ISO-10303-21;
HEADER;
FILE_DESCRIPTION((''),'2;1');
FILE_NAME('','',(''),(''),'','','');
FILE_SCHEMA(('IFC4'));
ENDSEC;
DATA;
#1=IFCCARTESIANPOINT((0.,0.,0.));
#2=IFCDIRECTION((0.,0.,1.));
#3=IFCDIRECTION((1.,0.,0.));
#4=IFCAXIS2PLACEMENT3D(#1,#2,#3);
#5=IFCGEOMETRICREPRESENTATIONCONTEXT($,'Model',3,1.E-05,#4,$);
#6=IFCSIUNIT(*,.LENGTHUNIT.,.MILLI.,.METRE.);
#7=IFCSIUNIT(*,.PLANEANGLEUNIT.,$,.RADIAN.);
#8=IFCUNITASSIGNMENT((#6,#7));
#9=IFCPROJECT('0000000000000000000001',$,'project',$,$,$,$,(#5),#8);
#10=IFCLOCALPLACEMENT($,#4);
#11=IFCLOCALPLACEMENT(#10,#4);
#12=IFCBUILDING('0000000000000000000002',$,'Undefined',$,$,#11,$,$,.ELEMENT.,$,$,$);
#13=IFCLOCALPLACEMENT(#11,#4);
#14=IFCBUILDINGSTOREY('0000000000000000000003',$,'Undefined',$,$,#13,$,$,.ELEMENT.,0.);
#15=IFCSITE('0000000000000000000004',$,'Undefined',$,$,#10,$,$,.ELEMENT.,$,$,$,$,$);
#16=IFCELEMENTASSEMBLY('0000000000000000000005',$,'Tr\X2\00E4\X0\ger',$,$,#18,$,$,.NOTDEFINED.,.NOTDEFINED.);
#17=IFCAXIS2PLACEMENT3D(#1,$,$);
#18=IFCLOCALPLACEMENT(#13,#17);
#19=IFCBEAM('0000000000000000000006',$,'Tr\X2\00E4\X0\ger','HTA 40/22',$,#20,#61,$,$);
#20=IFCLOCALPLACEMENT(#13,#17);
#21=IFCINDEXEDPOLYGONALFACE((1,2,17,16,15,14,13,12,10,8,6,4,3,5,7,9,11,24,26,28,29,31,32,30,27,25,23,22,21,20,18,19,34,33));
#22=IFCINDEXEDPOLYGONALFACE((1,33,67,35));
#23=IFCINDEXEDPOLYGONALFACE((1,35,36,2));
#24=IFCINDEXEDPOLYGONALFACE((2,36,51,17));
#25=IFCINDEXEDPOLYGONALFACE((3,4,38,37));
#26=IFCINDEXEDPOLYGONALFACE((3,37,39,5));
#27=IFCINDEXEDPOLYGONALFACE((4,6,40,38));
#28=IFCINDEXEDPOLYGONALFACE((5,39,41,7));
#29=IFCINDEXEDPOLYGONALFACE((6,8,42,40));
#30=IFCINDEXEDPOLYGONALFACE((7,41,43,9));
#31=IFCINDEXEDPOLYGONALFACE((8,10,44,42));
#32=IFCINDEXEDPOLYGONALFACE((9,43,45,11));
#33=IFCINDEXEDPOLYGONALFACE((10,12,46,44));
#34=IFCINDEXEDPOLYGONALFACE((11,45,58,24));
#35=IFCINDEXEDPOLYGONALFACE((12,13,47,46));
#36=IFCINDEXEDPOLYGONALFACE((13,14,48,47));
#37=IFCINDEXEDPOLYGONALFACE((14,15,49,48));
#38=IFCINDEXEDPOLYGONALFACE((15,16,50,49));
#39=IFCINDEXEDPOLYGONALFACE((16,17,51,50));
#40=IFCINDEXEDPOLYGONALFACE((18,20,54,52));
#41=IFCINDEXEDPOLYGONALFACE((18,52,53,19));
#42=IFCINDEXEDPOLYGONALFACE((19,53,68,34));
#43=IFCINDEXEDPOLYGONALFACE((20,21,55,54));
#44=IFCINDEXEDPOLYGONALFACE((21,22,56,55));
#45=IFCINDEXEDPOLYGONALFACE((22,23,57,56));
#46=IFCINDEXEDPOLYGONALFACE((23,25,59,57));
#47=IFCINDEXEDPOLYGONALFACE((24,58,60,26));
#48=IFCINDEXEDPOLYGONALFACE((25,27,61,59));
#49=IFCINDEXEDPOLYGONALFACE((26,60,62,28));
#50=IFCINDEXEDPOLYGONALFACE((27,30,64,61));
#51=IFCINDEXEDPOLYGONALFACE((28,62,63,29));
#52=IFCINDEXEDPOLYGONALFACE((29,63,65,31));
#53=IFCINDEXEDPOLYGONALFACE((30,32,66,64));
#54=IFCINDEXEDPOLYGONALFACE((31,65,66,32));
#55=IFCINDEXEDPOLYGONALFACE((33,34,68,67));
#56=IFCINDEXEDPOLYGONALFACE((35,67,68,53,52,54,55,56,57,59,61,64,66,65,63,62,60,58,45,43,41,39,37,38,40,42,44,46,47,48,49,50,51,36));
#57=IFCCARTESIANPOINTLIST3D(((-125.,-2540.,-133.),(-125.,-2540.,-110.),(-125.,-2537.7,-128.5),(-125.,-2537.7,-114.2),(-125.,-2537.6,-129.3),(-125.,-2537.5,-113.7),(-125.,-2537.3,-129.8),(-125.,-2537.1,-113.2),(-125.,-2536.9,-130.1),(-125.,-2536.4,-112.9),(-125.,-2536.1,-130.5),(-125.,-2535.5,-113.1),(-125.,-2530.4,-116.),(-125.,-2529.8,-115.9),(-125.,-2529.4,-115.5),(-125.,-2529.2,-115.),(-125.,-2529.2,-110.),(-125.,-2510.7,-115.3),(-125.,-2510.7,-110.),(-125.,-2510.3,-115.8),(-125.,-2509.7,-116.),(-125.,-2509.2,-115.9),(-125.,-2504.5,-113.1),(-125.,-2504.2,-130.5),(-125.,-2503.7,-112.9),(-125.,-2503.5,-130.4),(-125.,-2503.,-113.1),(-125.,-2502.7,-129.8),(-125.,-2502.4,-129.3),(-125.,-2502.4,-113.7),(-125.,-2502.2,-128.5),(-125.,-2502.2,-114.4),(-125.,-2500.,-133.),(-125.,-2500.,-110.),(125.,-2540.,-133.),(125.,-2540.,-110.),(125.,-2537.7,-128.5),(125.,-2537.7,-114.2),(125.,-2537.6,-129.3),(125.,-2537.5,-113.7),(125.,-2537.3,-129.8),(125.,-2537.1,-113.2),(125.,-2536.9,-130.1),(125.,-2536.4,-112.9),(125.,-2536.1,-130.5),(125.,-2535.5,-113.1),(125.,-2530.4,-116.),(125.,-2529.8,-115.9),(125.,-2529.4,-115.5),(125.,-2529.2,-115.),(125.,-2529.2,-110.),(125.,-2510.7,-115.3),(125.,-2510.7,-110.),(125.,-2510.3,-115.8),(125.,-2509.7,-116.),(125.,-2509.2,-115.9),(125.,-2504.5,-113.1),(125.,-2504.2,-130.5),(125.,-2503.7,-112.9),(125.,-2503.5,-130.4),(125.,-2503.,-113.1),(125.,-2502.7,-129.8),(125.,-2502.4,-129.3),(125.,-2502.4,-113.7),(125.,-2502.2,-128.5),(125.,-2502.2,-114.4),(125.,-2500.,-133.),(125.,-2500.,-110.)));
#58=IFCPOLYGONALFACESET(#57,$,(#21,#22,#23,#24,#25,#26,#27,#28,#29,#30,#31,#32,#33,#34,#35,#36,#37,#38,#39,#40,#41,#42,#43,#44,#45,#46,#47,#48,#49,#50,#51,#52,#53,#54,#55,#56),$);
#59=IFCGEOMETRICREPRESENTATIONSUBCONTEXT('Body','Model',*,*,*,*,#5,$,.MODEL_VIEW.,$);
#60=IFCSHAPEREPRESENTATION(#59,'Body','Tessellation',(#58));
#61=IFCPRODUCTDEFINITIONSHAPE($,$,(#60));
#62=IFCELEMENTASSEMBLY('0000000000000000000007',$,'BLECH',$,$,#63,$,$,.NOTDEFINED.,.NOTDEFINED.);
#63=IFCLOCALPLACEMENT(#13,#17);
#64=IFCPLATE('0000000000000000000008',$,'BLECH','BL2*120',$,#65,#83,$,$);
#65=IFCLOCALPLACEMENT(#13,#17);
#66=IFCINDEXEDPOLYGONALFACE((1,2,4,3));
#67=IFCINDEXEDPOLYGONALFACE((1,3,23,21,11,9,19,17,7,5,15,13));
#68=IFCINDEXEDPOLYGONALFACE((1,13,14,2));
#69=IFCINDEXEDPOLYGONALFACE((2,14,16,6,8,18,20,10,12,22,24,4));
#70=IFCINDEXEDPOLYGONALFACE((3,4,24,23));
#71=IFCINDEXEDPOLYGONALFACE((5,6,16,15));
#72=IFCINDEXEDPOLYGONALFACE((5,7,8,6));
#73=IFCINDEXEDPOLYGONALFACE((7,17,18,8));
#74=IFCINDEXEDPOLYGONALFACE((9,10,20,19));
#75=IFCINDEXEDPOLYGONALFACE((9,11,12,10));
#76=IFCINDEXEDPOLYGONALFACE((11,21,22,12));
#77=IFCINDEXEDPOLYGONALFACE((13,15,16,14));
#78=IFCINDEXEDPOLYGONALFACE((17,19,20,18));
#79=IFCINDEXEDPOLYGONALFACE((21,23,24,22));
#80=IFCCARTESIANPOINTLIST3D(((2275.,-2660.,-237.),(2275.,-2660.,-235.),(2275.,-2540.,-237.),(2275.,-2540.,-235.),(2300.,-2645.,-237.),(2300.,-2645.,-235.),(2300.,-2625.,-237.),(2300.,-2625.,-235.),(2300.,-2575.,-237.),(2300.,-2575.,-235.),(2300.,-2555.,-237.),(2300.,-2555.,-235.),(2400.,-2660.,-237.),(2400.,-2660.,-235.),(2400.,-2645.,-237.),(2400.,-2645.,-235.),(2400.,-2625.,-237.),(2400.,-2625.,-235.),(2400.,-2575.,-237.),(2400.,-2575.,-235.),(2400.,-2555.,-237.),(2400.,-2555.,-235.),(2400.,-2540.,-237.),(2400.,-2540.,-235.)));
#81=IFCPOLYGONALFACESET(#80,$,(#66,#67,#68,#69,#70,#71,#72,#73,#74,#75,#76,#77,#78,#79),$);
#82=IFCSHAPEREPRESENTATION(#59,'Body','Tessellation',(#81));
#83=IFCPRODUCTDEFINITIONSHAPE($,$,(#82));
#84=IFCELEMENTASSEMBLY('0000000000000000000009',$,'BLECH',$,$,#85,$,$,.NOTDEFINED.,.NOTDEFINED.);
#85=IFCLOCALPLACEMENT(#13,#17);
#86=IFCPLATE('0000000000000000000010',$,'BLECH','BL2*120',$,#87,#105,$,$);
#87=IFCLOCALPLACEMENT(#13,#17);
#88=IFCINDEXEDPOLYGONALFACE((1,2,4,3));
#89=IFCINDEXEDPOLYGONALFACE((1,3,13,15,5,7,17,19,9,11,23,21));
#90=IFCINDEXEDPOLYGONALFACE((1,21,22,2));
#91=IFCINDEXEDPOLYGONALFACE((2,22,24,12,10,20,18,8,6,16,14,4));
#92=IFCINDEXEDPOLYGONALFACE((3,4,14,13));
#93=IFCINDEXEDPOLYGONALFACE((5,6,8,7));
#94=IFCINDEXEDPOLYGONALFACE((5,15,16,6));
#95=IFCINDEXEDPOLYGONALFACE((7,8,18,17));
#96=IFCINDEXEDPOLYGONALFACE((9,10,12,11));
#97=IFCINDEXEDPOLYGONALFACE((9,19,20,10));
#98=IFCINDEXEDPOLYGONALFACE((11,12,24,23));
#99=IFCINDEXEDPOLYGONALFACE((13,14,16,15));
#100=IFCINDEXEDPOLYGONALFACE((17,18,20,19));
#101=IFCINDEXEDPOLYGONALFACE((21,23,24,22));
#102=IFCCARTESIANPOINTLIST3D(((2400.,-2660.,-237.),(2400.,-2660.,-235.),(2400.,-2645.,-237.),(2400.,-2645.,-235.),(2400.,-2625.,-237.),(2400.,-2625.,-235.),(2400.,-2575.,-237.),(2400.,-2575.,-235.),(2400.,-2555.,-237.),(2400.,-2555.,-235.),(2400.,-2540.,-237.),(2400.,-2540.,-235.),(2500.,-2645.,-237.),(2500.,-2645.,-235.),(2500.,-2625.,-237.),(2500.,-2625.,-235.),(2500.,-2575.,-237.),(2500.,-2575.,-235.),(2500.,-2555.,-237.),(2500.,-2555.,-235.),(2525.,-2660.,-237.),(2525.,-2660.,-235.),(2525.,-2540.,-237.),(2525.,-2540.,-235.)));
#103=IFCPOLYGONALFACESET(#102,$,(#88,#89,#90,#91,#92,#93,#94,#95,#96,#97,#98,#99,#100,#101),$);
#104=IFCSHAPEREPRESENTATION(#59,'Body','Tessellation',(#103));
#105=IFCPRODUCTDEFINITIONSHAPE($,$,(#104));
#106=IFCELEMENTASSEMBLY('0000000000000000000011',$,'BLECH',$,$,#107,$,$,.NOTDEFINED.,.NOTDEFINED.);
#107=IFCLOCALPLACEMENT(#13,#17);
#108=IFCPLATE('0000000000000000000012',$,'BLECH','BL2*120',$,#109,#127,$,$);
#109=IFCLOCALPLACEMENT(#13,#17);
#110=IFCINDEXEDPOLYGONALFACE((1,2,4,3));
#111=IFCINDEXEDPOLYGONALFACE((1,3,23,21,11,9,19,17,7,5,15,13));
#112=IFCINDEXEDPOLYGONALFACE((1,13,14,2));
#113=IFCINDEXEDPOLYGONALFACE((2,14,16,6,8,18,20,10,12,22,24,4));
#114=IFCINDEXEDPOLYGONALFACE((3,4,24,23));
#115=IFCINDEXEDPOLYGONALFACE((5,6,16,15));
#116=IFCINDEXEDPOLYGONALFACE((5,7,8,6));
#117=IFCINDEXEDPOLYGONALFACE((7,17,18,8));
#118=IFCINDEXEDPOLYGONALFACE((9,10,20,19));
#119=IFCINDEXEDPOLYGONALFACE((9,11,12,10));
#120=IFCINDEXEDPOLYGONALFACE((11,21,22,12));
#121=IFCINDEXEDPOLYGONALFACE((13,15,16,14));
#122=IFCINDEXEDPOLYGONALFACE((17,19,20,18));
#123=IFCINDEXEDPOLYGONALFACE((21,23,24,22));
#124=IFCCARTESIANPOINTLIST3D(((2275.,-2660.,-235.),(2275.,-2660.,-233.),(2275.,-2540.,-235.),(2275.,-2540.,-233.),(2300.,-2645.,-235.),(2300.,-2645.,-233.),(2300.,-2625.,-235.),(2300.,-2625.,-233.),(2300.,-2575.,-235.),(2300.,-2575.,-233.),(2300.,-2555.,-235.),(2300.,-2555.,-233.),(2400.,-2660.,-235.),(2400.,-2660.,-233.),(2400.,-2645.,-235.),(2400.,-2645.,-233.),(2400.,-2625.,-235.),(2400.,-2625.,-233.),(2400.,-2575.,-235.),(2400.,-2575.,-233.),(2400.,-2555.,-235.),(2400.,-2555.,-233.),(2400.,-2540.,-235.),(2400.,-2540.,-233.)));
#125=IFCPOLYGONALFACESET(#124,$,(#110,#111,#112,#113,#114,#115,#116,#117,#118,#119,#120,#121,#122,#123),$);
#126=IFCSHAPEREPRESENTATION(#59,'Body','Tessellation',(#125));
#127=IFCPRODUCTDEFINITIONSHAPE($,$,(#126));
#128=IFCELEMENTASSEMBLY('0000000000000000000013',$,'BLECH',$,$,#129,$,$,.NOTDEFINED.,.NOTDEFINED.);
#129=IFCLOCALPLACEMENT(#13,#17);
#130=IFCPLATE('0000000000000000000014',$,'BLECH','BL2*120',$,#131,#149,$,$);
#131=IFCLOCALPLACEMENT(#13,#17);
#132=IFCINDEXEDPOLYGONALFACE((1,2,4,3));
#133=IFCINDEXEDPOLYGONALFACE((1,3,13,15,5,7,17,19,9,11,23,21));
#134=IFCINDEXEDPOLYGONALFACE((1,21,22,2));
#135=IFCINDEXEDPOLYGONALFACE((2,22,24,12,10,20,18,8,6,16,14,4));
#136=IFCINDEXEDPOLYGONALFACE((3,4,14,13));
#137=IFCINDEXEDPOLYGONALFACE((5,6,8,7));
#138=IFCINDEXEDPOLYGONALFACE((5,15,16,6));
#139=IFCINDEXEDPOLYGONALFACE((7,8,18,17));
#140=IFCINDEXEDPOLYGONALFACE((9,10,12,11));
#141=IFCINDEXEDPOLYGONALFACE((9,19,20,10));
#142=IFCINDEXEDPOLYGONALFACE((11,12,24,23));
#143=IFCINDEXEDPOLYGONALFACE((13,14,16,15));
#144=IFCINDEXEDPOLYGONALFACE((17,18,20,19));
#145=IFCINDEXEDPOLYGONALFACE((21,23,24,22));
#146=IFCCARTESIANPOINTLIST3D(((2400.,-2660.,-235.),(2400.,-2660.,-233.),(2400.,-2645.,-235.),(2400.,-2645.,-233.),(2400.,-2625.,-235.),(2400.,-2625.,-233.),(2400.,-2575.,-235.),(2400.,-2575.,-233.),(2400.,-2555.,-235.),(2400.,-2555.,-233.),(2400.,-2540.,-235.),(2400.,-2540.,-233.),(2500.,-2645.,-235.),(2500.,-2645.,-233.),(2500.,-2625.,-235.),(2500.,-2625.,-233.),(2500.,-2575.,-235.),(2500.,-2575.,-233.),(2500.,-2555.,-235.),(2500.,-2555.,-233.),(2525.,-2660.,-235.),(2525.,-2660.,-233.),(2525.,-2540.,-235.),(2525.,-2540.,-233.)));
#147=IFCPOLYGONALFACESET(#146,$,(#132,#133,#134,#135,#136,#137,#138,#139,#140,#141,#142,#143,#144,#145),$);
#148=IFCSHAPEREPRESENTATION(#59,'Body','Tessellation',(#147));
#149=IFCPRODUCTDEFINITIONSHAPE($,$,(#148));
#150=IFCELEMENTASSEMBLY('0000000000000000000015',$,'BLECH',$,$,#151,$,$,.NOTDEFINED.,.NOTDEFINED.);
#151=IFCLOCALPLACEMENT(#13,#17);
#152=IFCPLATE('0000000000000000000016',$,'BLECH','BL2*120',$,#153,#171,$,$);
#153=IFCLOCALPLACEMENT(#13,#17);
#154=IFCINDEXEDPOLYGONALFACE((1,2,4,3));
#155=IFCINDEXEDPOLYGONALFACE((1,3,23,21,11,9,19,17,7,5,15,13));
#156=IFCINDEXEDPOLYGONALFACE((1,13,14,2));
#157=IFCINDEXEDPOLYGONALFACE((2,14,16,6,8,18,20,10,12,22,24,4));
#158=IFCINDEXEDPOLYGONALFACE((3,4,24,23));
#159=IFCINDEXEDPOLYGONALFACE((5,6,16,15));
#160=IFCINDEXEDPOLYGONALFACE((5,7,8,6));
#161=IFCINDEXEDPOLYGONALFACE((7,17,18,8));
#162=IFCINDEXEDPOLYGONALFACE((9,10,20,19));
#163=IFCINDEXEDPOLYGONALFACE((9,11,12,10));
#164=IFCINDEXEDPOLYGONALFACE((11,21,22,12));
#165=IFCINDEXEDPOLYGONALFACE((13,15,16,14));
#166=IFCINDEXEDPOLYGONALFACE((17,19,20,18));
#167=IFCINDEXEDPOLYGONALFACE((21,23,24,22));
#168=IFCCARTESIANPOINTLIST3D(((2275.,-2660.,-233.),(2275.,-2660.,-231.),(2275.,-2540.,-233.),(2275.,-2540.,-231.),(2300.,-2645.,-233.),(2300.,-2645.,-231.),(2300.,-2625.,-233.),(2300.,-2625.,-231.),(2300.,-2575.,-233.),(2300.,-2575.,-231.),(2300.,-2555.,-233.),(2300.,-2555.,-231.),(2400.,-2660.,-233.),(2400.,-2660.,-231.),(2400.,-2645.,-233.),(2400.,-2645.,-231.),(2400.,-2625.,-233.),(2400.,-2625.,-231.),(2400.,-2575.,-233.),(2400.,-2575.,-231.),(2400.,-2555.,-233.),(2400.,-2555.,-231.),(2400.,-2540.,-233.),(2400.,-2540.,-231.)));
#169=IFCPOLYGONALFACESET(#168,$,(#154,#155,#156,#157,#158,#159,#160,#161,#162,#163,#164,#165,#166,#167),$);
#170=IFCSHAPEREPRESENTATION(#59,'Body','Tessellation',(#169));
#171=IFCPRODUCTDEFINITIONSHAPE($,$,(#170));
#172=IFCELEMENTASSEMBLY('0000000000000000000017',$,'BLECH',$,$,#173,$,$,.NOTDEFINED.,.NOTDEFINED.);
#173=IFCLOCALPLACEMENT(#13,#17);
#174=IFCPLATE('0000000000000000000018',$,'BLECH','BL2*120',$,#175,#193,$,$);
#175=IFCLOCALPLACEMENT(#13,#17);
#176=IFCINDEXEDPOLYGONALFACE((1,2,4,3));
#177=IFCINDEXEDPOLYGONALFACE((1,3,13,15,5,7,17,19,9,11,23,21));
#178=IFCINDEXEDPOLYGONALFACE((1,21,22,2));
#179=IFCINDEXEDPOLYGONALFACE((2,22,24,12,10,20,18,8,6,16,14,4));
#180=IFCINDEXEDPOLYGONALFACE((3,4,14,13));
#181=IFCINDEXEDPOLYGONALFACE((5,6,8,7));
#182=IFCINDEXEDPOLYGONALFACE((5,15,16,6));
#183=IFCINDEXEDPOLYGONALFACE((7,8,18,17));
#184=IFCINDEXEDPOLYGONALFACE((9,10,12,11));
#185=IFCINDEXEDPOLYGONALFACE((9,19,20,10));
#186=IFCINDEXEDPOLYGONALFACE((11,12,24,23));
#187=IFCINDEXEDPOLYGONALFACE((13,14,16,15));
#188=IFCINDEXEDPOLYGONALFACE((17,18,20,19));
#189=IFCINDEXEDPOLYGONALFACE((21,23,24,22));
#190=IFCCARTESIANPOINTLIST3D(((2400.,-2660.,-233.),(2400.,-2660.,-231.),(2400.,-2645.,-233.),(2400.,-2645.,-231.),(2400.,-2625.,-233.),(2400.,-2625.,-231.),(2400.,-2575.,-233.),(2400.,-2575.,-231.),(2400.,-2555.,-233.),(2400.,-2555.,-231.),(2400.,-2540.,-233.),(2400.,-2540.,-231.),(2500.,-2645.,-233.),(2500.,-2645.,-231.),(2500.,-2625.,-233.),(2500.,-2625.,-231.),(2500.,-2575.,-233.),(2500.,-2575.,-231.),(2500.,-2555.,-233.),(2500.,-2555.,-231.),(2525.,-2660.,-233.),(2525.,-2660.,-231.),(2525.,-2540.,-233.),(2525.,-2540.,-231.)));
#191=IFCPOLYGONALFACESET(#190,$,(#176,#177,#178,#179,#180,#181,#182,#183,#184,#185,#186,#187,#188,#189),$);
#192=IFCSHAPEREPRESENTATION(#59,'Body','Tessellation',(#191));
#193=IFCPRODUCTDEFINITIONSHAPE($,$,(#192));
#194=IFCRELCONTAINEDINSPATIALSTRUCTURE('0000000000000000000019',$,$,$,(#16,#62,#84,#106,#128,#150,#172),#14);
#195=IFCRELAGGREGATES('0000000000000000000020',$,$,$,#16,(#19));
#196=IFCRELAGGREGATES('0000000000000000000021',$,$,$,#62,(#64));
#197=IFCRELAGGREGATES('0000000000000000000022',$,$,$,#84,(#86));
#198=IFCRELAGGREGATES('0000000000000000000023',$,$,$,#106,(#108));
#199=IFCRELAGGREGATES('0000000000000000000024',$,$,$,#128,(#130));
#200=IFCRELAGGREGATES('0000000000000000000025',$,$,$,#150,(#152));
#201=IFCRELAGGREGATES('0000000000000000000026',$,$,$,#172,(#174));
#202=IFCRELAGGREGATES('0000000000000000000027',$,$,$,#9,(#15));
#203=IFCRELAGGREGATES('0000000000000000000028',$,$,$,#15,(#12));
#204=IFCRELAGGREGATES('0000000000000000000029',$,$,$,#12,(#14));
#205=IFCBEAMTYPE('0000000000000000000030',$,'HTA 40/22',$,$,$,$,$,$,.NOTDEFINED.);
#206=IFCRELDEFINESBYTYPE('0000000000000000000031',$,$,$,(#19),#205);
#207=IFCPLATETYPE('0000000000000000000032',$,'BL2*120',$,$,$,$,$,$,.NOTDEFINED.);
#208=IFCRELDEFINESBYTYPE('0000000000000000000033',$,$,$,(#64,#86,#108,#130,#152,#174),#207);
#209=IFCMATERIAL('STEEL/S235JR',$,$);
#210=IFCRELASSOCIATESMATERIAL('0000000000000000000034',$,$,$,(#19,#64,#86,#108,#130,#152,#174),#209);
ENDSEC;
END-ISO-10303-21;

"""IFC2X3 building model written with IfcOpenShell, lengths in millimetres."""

from ifc_helpers import new_model, si_unit, frame, origin_with_axes, place, context, subcontext, project, spatial, polyline, outline, extrude, material, type_object, element, aggregate, save


model = new_model("IFC2X3")

# Units and contexts
model_context = context("Model", 3, precision=1e-05, world=origin_with_axes())
body_context = subcontext(model_context, "Body", "Model", "MODEL_VIEW")
ifc_project = project(units=[si_unit("LENGTHUNIT", "METRE", prefix="MILLI"), si_unit("PLANEANGLEUNIT", "RADIAN")], contexts=[model_context])

# Site, building, storey
site_placement = place(None, origin_with_axes())
site = spatial("IfcSite", under=ifc_project, at=site_placement, Name="Undefined", CompositionType="ELEMENT")
building_placement = place(site_placement, origin_with_axes())
building = spatial("IfcBuilding", under=site, at=building_placement, Name="Undefined", CompositionType="ELEMENT")
storey_placement = place(building_placement, origin_with_axes())
storey = spatial("IfcBuildingStorey", under=building, at=storey_placement, Name="Undefined", CompositionType="ELEMENT", Elevation=0.0)

# Element assembly, beam
assembly_1_placement = place(storey_placement, origin_with_axes())
assembly_1 = element("IfcElementAssembly", 1, at=assembly_1_placement, inside=storey, Name="Träger", AssemblyPlace="NOTDEFINED", PredefinedType="NOTDEFINED")
ifc_material = material(Name="STEEL/S235JR")
beam_type = type_object("IfcBeamType", Name="HTA 40/22", PredefinedType="NOTDEFINED")
beam_placement = place(assembly_1_placement, frame((125.0, -2520.0, -121.5), z_axis=(0.0, 0.0, -1.0), x_axis=(-1.0, 0.0, 0.0)))
beam = element("IfcBeam", 2, at=beam_placement, type_object=beam_type, material=ifc_material, Name="Träger", Description="HTA 40/22", context=body_context, shape_type="SweptSolid", body=[
    extrude(outline(polyline([(-9.3, -6.2), (-9.2, -11.5), (-20.0, -11.5), (-20.0, 11.5), (20.0, 11.5), (20.0, -11.5), (9.2, -11.5), (9.2, -6.5), (9.4, -6.0), (9.8, -5.6), (10.4, -5.5), (15.5, -8.4), (16.4, -8.6), (17.1, -8.3), (17.5, -7.8), (17.7, -7.3), (17.8, 7.0), (17.6, 7.8), (17.3, 8.3), (16.9, 8.6), (16.1, 9.0), (-15.8, 9.0), (-16.5, 8.9), (-17.3, 8.3), (-17.6, 7.8), (-17.8, 7.0), (-17.8, -7.1), (-17.5, -7.8), (-17.0, -8.4), (-16.2, -8.6), (-15.5, -8.4), (-10.8, -5.6), (-10.2, -5.5), (-9.7, -5.7), (-9.3, -6.2)])), frame((250.0, 0.0, 0.0), z_axis=(-1.0, 0.0, 0.0), x_axis=(0.0, -1.0, 0.0)), (0.0, 0.0, 1.0), 250.0),
])
aggregate(assembly_1, [beam])

# Element assemblies, plates
assembly_2_placement = place(storey_placement, origin_with_axes())
assembly_2 = element("IfcElementAssembly", 3, at=assembly_2_placement, inside=storey, Name="BLECH", AssemblyPlace="NOTDEFINED", PredefinedType="NOTDEFINED")
plate_type_1 = type_object("IfcPlateType", Name="BL2*120", PredefinedType="NOTDEFINED")
plate_1_placement = place(assembly_2_placement, frame((2275.0, -2540.0, -236.0), z_axis=(0.0, 0.0, -1.0), x_axis=(1.0, 0.0, 0.0)))
plate_1 = element("IfcPlate", 4, at=plate_1_placement, type_object=plate_type_1, material=ifc_material, Name="BLECH", Description="BL2*120", context=body_context, shape_type="SweptSolid", body=[
    extrude(outline(polyline([(0.0, 0.0), (125.0, 0.0), (125.0, 15.0), (25.0, 15.0), (25.0, 35.0), (125.0, 35.0), (125.0, 85.0), (25.0, 85.0), (25.0, 105.0), (125.0, 105.0), (125.0, 120.0), (0.0, 120.0), (0.0, 0.0)])), frame((0.0, 0.0, -1.0), z_axis=(0.0, 0.0, 1.0), x_axis=(1.0, 0.0, 0.0)), (0.0, 0.0, 1.0), 2.0),
])
aggregate(assembly_2, [plate_1])
assembly_3_placement = place(storey_placement, origin_with_axes())
assembly_3 = element("IfcElementAssembly", 5, at=assembly_3_placement, inside=storey, Name="BLECH", AssemblyPlace="NOTDEFINED", PredefinedType="NOTDEFINED")
plate_2_placement = place(assembly_3_placement, frame((2525.0, -2540.0, -236.0), z_axis=(0.0, 0.0, 1.0), x_axis=(-1.0, 0.0, 0.0)))
plate_2 = element("IfcPlate", 6, at=plate_2_placement, type_object=plate_type_1, material=ifc_material, Name="BLECH", Description="BL2*120", context=body_context, shape_type="SweptSolid", body=[
    extrude(outline(polyline([(0.0, 0.0), (125.0, 0.0), (125.0, 15.0), (25.0, 15.0), (25.0, 35.0), (125.0, 35.0), (125.0, 85.0), (25.0, 85.0), (25.0, 105.0), (125.0, 105.0), (125.0, 120.0), (0.0, 120.0), (0.0, 0.0)])), frame((0.0, 0.0, -1.0), z_axis=(0.0, 0.0, 1.0), x_axis=(1.0, 0.0, 0.0)), (0.0, 0.0, 1.0), 2.0),
])
aggregate(assembly_3, [plate_2])
assembly_4_placement = place(storey_placement, origin_with_axes())
assembly_4 = element("IfcElementAssembly", 7, at=assembly_4_placement, inside=storey, Name="BLECH", AssemblyPlace="NOTDEFINED", PredefinedType="NOTDEFINED")
plate_3_placement = place(assembly_4_placement, frame((2275.0, -2540.0, -234.0), z_axis=(0.0, 0.0, -1.0), x_axis=(1.0, 0.0, 0.0)))
plate_3 = element("IfcPlate", 8, at=plate_3_placement, type_object=plate_type_1, material=ifc_material, Name="BLECH", Description="BL2*120", context=body_context, shape_type="SweptSolid", body=[
    extrude(outline(polyline([(0.0, 0.0), (125.0, 0.0), (125.0, 15.0), (25.0, 15.0), (25.0, 35.0), (125.0, 35.0), (125.0, 85.0), (25.0, 85.0), (25.0, 105.0), (125.0, 105.0), (125.0, 120.0), (0.0, 120.0), (0.0, 0.0)])), frame((0.0, 0.0, -1.0), z_axis=(0.0, 0.0, 1.0), x_axis=(1.0, 0.0, 0.0)), (0.0, 0.0, 1.0), 2.0),
])
aggregate(assembly_4, [plate_3])
assembly_5_placement = place(storey_placement, origin_with_axes())
assembly_5 = element("IfcElementAssembly", 9, at=assembly_5_placement, inside=storey, Name="BLECH", AssemblyPlace="NOTDEFINED", PredefinedType="NOTDEFINED")
plate_4_placement = place(assembly_5_placement, frame((2525.0, -2540.0, -234.0), z_axis=(0.0, 0.0, 1.0), x_axis=(-1.0, 0.0, 0.0)))
plate_4 = element("IfcPlate", 10, at=plate_4_placement, type_object=plate_type_1, material=ifc_material, Name="BLECH", Description="BL2*120", context=body_context, shape_type="SweptSolid", body=[
    extrude(outline(polyline([(0.0, 0.0), (125.0, 0.0), (125.0, 15.0), (25.0, 15.0), (25.0, 35.0), (125.0, 35.0), (125.0, 85.0), (25.0, 85.0), (25.0, 105.0), (125.0, 105.0), (125.0, 120.0), (0.0, 120.0), (0.0, 0.0)])), frame((0.0, 0.0, -1.0), z_axis=(0.0, 0.0, 1.0), x_axis=(1.0, 0.0, 0.0)), (0.0, 0.0, 1.0), 2.0),
])
aggregate(assembly_5, [plate_4])
assembly_6_placement = place(storey_placement, origin_with_axes())
assembly_6 = element("IfcElementAssembly", 11, at=assembly_6_placement, inside=storey, Name="BLECH", AssemblyPlace="NOTDEFINED", PredefinedType="NOTDEFINED")
plate_5_placement = place(assembly_6_placement, frame((2275.0, -2540.0, -232.0), z_axis=(0.0, 0.0, -1.0), x_axis=(1.0, 0.0, 0.0)))
plate_5 = element("IfcPlate", 12, at=plate_5_placement, type_object=plate_type_1, material=ifc_material, Name="BLECH", Description="BL2*120", context=body_context, shape_type="SweptSolid", body=[
    extrude(outline(polyline([(0.0, 0.0), (125.0, 0.0), (125.0, 15.0), (25.0, 15.0), (25.0, 35.0), (125.0, 35.0), (125.0, 85.0), (25.0, 85.0), (25.0, 105.0), (125.0, 105.0), (125.0, 120.0), (0.0, 120.0), (0.0, 0.0)])), frame((0.0, 0.0, -1.0), z_axis=(0.0, 0.0, 1.0), x_axis=(1.0, 0.0, 0.0)), (0.0, 0.0, 1.0), 2.0),
])
aggregate(assembly_6, [plate_5])
assembly_7_placement = place(storey_placement, origin_with_axes())
assembly_7 = element("IfcElementAssembly", 13, at=assembly_7_placement, inside=storey, Name="BLECH", AssemblyPlace="NOTDEFINED", PredefinedType="NOTDEFINED")
plate_6_placement = place(assembly_7_placement, frame((2525.0, -2540.0, -232.0), z_axis=(0.0, 0.0, 1.0), x_axis=(-1.0, 0.0, 0.0)))
plate_6 = element("IfcPlate", 14, at=plate_6_placement, type_object=plate_type_1, material=ifc_material, Name="BLECH", Description="BL2*120", context=body_context, shape_type="SweptSolid", body=[
    extrude(outline(polyline([(0.0, 0.0), (125.0, 0.0), (125.0, 15.0), (25.0, 15.0), (25.0, 35.0), (125.0, 35.0), (125.0, 85.0), (25.0, 85.0), (25.0, 105.0), (125.0, 105.0), (125.0, 120.0), (0.0, 120.0), (0.0, 0.0)])), frame((0.0, 0.0, -1.0), z_axis=(0.0, 0.0, 1.0), x_axis=(1.0, 0.0, 0.0)), (0.0, 0.0, 1.0), 2.0),
])
aggregate(assembly_7, [plate_6])

save(model, "model.ifc")
